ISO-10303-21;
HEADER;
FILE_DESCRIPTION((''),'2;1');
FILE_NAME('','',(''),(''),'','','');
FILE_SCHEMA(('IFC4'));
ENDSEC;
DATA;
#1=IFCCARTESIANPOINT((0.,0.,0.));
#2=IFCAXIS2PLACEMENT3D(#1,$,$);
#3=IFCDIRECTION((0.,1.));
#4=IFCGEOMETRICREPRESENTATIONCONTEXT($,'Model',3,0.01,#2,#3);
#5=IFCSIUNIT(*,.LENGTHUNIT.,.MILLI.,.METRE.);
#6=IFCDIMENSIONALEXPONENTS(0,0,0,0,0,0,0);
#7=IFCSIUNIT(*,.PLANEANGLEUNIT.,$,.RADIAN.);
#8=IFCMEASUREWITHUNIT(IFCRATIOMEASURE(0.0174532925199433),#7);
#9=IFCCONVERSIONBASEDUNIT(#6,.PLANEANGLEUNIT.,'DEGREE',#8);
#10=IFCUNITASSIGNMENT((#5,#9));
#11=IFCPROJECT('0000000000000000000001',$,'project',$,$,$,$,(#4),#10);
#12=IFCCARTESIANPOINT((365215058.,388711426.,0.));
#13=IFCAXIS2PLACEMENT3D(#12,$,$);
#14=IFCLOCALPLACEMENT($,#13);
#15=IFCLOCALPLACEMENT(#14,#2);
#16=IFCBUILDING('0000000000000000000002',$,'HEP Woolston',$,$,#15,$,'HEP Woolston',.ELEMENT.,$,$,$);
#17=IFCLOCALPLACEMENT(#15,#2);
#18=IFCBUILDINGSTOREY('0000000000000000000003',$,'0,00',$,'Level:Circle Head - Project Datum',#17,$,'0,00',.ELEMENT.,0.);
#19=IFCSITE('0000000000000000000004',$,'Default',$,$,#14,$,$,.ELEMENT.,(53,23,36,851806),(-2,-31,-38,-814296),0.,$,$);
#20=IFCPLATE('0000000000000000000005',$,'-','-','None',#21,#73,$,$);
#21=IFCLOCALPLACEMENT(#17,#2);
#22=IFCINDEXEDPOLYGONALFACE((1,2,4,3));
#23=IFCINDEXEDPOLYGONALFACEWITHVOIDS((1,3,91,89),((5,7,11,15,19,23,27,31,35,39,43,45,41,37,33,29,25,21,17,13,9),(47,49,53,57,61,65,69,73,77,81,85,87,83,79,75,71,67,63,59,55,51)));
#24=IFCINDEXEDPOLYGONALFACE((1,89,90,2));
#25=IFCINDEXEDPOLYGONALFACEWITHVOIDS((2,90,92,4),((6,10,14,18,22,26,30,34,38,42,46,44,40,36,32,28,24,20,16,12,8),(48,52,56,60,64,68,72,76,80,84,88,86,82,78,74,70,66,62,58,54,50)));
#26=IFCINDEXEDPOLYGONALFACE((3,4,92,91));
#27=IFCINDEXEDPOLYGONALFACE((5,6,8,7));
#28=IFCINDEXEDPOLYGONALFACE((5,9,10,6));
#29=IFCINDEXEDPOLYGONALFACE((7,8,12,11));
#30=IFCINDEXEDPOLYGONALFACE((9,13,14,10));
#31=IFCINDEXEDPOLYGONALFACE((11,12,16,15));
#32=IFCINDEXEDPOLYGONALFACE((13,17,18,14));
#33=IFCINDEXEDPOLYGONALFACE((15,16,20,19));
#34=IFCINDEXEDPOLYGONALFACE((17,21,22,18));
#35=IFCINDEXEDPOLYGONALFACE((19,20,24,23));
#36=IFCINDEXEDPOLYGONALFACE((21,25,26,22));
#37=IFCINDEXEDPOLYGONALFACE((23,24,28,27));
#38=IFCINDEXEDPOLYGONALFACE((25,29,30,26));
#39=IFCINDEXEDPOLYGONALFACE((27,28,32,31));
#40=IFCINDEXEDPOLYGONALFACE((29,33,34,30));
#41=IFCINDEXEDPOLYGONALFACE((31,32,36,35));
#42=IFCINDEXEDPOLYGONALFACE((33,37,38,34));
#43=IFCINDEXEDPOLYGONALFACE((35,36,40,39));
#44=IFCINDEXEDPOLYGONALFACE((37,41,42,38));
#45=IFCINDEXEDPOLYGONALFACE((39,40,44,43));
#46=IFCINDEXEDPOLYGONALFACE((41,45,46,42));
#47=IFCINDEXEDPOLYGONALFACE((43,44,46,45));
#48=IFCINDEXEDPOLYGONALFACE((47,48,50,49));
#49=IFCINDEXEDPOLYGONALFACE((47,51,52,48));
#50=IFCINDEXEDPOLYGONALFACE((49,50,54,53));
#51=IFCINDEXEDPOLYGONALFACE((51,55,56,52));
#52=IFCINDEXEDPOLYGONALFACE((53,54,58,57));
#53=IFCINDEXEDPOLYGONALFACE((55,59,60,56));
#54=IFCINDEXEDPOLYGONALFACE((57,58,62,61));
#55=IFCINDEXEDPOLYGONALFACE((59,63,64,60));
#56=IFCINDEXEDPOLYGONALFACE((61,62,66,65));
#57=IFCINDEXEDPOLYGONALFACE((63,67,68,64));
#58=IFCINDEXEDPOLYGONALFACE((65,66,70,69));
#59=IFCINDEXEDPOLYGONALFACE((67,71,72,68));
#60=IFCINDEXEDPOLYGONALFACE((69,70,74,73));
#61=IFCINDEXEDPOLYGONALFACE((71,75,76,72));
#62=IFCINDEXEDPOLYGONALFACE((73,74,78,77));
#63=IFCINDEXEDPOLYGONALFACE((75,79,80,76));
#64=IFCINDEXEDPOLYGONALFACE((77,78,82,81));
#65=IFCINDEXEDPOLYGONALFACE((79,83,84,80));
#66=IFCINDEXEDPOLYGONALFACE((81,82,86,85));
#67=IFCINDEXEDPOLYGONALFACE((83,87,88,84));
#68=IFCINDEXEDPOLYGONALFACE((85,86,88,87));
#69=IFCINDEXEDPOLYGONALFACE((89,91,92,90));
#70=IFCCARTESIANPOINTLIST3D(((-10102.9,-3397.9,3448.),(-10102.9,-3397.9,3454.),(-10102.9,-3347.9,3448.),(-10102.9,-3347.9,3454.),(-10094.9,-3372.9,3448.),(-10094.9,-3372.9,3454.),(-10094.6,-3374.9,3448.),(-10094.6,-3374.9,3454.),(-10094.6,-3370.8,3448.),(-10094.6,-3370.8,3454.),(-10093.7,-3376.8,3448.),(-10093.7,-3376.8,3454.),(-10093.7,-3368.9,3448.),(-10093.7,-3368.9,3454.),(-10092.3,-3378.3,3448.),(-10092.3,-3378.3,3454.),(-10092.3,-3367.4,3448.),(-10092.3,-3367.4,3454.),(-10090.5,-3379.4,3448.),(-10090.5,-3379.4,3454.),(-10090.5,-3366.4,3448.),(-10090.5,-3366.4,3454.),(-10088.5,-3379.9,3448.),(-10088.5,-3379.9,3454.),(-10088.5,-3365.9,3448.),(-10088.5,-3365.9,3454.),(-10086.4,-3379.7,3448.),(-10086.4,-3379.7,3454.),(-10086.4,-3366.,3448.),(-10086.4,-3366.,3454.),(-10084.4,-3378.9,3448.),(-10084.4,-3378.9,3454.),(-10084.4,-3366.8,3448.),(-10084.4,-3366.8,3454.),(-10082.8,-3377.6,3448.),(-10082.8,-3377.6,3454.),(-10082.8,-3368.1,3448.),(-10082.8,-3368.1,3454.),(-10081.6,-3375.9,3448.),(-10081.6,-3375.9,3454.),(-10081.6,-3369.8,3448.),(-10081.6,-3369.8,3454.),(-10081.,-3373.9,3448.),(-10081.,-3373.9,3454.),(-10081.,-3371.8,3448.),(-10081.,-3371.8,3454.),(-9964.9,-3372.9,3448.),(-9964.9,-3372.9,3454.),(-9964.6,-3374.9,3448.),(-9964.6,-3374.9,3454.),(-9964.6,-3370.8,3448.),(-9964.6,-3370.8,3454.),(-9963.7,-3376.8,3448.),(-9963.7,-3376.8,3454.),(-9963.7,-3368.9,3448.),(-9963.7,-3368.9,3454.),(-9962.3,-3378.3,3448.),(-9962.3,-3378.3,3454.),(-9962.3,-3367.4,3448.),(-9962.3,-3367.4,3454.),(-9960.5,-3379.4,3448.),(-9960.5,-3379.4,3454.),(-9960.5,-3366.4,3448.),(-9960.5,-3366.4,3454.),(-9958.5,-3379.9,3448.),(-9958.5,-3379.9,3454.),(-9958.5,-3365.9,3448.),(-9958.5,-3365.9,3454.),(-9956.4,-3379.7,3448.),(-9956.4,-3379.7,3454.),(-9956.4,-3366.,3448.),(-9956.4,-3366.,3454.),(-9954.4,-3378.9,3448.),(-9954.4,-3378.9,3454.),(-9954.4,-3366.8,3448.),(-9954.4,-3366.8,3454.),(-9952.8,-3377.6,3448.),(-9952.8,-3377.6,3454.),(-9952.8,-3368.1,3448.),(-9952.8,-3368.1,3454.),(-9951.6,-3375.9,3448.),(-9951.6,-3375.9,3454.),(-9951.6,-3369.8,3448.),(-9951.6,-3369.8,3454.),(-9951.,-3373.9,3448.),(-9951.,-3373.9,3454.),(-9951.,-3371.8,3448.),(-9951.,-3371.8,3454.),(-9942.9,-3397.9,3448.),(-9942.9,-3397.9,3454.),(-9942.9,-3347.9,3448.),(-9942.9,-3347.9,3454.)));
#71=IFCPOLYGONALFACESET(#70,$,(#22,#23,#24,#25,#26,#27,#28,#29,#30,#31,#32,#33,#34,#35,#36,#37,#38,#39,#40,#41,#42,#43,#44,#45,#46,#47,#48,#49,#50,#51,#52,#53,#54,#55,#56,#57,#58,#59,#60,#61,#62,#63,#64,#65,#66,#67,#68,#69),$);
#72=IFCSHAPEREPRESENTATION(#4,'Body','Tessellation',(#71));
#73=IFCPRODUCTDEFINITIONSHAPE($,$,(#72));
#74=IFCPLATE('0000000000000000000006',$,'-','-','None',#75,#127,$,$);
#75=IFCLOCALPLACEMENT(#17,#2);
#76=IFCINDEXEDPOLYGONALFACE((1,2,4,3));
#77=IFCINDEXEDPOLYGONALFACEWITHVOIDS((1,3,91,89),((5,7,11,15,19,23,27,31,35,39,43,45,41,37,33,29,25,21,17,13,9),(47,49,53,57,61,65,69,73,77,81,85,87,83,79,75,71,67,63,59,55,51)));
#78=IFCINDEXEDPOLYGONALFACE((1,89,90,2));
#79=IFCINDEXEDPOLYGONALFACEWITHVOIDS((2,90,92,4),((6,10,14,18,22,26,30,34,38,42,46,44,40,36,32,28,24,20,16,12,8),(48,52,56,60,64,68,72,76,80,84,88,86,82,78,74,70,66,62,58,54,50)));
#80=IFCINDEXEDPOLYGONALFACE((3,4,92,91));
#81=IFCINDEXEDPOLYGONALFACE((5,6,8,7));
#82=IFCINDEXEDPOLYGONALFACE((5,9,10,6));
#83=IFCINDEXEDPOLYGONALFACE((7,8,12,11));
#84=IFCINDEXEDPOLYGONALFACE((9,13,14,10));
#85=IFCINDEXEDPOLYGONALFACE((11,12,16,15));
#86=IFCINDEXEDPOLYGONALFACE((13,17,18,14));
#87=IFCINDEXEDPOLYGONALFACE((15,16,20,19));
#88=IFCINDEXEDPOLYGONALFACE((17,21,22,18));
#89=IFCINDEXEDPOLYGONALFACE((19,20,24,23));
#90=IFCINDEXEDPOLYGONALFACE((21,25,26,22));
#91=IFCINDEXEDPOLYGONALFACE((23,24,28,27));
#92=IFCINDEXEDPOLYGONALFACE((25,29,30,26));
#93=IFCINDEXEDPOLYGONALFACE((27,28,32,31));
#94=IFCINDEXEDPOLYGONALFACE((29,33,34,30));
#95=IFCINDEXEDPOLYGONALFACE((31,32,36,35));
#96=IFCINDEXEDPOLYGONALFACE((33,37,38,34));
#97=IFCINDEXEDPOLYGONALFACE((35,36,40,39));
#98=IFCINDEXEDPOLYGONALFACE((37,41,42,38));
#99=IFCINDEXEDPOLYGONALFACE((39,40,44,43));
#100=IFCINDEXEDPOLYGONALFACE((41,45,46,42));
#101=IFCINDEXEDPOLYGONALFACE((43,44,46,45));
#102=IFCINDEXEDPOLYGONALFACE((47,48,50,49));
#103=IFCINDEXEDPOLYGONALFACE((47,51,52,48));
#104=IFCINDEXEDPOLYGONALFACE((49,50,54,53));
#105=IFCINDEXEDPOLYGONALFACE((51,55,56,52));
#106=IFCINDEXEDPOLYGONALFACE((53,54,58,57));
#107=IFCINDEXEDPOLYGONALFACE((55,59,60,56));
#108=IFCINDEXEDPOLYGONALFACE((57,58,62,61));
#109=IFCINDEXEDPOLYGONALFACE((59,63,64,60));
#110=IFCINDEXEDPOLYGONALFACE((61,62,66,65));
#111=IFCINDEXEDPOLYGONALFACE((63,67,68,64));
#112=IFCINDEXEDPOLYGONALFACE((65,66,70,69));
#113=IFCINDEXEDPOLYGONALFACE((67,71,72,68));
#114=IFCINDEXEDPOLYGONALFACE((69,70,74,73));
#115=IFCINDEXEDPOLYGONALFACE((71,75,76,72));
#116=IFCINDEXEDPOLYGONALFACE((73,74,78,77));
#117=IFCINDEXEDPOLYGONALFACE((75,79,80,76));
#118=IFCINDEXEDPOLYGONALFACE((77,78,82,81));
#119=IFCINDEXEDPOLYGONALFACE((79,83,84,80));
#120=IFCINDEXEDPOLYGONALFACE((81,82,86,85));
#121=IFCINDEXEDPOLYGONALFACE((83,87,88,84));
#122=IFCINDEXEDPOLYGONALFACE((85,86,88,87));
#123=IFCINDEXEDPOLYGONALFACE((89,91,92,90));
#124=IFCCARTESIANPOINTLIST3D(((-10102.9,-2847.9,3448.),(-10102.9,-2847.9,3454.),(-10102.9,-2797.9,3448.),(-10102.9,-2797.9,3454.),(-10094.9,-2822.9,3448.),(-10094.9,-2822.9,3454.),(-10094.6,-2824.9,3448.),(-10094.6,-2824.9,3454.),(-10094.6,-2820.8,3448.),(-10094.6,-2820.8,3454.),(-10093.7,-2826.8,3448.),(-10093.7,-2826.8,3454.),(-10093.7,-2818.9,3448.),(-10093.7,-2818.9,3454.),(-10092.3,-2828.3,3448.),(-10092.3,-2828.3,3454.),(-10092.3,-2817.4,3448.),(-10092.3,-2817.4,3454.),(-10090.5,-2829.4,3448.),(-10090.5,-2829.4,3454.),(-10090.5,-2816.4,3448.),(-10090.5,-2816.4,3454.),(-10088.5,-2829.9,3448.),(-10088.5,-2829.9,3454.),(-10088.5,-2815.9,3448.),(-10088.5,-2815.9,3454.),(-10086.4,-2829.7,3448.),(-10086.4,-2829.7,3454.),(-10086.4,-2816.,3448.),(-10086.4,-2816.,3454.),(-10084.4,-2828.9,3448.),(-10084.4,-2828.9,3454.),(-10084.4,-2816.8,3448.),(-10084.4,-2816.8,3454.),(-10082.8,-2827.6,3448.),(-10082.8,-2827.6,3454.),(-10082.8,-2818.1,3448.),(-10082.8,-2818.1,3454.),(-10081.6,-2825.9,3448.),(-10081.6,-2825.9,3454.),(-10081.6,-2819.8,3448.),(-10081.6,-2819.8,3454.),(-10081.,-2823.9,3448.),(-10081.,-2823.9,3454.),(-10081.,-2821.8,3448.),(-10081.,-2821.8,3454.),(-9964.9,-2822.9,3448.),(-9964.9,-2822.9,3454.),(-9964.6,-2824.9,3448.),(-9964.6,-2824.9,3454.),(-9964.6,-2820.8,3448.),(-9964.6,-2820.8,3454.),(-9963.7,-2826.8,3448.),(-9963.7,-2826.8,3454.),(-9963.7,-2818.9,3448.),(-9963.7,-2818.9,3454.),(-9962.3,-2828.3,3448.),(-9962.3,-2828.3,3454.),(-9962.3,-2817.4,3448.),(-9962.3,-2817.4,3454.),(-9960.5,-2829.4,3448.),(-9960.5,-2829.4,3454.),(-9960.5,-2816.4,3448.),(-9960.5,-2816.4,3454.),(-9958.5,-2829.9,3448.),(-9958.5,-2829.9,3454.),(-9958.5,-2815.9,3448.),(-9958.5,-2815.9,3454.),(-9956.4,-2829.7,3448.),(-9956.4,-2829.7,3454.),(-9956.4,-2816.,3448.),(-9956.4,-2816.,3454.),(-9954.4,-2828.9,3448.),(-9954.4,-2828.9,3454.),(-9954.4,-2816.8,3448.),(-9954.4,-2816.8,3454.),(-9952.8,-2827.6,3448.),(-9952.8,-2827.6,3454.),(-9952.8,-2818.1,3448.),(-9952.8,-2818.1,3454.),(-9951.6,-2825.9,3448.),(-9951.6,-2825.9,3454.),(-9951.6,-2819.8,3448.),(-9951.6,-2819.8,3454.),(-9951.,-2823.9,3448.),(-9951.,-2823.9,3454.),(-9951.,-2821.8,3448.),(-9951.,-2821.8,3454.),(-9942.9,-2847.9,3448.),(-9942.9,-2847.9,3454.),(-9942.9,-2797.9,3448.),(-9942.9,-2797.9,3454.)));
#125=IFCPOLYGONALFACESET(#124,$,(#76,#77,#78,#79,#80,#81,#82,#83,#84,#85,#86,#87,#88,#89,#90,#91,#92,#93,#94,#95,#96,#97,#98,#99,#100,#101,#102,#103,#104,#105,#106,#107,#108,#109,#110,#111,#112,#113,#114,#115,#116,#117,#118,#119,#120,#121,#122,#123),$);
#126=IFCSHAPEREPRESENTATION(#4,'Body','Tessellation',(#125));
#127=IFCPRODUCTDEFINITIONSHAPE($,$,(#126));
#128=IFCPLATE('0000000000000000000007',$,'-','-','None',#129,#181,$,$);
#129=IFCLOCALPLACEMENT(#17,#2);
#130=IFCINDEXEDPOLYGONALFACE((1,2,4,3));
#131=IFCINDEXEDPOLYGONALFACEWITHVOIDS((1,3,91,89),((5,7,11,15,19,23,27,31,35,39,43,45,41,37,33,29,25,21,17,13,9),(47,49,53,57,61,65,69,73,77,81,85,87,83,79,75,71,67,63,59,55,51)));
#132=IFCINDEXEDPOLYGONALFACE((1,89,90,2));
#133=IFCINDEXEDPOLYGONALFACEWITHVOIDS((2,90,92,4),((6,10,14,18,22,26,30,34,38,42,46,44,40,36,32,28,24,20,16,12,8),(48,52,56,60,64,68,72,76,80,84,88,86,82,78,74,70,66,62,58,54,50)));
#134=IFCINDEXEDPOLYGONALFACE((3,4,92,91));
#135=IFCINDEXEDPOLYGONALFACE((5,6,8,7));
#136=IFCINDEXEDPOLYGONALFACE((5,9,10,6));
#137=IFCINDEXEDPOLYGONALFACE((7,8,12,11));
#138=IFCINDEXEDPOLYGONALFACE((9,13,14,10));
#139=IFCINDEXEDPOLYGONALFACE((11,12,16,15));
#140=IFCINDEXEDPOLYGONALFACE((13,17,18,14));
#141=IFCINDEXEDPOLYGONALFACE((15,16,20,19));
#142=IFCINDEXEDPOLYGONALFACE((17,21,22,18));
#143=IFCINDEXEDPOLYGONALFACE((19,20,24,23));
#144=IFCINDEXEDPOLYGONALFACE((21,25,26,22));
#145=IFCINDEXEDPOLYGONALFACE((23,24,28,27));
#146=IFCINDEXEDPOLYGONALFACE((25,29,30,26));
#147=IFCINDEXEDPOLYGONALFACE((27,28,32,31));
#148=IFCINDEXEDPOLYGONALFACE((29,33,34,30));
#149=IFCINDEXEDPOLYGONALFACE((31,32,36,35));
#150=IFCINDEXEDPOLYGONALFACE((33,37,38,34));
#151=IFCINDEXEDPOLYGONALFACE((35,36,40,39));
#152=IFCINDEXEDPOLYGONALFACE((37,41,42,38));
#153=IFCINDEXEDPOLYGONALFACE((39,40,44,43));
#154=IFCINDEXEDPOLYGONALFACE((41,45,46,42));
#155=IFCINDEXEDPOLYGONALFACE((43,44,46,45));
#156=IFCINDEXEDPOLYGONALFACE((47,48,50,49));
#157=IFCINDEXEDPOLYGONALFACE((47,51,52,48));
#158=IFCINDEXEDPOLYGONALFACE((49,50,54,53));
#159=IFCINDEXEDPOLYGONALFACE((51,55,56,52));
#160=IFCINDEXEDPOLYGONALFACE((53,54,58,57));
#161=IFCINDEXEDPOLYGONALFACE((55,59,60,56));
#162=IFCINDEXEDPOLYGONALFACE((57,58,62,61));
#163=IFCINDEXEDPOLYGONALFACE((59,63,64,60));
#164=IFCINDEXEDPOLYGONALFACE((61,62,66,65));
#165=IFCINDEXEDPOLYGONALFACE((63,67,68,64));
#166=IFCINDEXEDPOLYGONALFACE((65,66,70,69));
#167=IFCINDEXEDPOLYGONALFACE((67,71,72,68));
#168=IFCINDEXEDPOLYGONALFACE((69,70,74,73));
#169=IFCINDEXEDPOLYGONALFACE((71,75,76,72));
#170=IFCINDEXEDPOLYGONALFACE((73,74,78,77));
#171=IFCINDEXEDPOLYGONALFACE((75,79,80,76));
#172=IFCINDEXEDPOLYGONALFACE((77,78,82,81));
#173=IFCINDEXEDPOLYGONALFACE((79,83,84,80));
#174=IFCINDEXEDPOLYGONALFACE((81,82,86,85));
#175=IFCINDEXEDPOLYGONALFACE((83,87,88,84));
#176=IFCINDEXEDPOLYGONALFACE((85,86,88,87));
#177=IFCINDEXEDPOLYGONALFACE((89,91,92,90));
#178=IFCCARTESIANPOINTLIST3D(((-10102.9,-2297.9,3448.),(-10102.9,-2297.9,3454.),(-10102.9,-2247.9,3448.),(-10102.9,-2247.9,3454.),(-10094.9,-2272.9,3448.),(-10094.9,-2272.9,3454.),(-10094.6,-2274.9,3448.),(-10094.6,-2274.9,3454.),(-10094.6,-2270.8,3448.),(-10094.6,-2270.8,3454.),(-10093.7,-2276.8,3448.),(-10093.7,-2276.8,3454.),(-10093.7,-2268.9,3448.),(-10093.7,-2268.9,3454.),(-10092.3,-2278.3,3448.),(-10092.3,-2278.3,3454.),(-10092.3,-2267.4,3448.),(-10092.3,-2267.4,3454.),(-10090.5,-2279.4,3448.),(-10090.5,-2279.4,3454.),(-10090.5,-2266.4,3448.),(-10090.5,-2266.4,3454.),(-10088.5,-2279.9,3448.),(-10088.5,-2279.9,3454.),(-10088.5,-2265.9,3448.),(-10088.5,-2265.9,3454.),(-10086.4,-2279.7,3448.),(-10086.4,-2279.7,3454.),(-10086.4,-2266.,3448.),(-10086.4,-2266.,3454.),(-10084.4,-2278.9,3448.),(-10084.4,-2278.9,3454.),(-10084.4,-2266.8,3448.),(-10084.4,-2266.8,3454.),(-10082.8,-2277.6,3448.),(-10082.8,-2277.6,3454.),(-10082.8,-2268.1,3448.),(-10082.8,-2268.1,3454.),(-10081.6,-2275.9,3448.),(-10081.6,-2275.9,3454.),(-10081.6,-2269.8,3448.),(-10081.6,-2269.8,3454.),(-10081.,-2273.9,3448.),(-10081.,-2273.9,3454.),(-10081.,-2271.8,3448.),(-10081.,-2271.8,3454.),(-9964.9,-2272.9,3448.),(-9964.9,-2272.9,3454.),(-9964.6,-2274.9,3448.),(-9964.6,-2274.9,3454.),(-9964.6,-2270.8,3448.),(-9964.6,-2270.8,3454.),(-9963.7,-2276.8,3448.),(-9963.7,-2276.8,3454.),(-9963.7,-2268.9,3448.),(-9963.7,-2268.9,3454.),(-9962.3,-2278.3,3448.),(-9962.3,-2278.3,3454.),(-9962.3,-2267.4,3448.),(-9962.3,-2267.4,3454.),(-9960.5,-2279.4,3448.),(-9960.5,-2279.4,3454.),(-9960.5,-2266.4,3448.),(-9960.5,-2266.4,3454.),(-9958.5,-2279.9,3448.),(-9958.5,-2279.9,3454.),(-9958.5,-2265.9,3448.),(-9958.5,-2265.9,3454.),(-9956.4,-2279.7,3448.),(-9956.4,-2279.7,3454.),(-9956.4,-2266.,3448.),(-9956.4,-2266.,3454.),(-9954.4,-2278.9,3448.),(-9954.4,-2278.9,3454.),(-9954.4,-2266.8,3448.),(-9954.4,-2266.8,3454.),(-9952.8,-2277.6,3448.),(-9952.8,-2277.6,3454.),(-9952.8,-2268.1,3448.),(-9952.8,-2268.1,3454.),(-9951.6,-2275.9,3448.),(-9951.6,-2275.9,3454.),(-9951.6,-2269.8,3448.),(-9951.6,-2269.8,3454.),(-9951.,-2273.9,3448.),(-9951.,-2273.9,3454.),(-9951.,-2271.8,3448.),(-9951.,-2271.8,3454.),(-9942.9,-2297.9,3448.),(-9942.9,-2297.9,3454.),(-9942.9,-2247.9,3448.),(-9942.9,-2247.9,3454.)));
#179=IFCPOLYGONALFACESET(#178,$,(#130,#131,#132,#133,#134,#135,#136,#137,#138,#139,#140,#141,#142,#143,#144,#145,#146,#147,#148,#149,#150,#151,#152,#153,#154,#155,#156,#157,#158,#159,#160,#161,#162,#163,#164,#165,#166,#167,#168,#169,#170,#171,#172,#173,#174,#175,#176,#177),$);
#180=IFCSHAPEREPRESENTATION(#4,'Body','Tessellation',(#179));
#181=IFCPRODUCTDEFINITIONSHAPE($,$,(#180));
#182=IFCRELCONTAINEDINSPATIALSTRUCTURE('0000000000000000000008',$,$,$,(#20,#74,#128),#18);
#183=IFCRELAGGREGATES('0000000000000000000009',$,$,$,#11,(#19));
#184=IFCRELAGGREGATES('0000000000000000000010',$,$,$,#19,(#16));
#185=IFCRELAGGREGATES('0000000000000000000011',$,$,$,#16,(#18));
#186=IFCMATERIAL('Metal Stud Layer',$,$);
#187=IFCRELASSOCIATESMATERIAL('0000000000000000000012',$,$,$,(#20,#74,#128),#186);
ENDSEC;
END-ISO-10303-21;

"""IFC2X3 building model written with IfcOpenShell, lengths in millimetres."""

from ifc_helpers import new_model, entity, si_unit, converted_unit, direction, frame, frame_2d, origin, origin_with_axes, place, context, project, spatial, polyline, circle, outline, extrude, material, element, save


model = new_model("IFC2X3")

# Units and contexts
model_context = context("Model", 3, precision=0.01, world=origin(), true_north=direction((0.0, 1.0)))
ifc_project = project(units=[si_unit("LENGTHUNIT", "METRE", prefix="MILLI"), converted_unit("PLANEANGLEUNIT", "DEGREE", entity("IfcRatioMeasure", 0.0174532925199433), si_unit("PLANEANGLEUNIT", "RADIAN"), dimensions=[0, 0, 0, 0, 0, 0, 0])], contexts=[model_context])

# Site, building, storey
site_placement = place(None, frame((365215058.0, 388711426.0, 0.0)))
site = spatial("IfcSite", under=ifc_project, at=site_placement, Name="Default", CompositionType="ELEMENT", RefLatitude=(53, 23, 36, 851806), RefLongitude=(-2, -31, -38, -814296), RefElevation=0.0)
building_placement = place(site_placement, origin())
building = spatial("IfcBuilding", under=site, at=building_placement, Name="HEP Woolston", LongName="HEP Woolston", CompositionType="ELEMENT")
storey_placement = place(building_placement, origin())
storey = spatial("IfcBuildingStorey", under=building, at=storey_placement, Name="0,00", ObjectType="Level:Circle Head - Project Datum", LongName="0,00", CompositionType="ELEMENT", Elevation=0.0)

# Plates, openings
ifc_material = material(Name="Metal Stud Layer")
plate_1_placement = place(storey_placement, frame((-9942.9, -3397.9, 3454.0), z_axis=(0.0, 0.0, -1.0), x_axis=(-1.0, 0.0, 0.0)))
plate_1 = element("IfcPlate", 1, at=plate_1_placement, inside=storey, material=ifc_material, Name="-", Description="-", ObjectType="None", context=model_context, shape_type="SweptSolid", body=[
    extrude(outline(polyline([(160.0, 0.0), (160.0, 50.0), (0.0, 50.0), (0.0, 0.0), (160.0, 0.0)])), origin_with_axes(), (0.0, 0.0, 1.0), 6.0),
])
opening_1_placement = place(plate_1_placement, frame((80.0, 25.0, 6.5), z_axis=(0.0, 0.0, -1.0), x_axis=(1.0, 0.0, 0.0)))
element("IfcOpeningElement", 2, at=opening_1_placement, cuts=plate_1, ObjectType="Opening", context=model_context, shape_type="SweptSolid", body=[
    extrude(circle(Radius=7.0, at=frame_2d((65.0, 0.0), x_axis=(1.0, 0.0))), origin(), (0.0, 0.0, 1.0), 7.0),
])
opening_2_placement = place(plate_1_placement, frame((80.0, 25.0, 6.5), z_axis=(0.0, 0.0, -1.0), x_axis=(1.0, 0.0, 0.0)))
element("IfcOpeningElement", 3, at=opening_2_placement, cuts=plate_1, ObjectType="Opening", context=model_context, shape_type="SweptSolid", body=[
    extrude(circle(Radius=7.0, at=frame_2d((-65.0, 0.0), x_axis=(1.0, 0.0))), origin(), (0.0, 0.0, 1.0), 7.0),
])
plate_2_placement = place(storey_placement, frame((-9942.9, -2847.9, 3454.0), z_axis=(0.0, 0.0, -1.0), x_axis=(-1.0, 0.0, 0.0)))
plate_2 = element("IfcPlate", 4, at=plate_2_placement, inside=storey, material=ifc_material, Name="-", Description="-", ObjectType="None", context=model_context, shape_type="SweptSolid", body=[
    extrude(outline(polyline([(160.0, 0.0), (160.0, 50.0), (0.0, 50.0), (0.0, 0.0), (160.0, 0.0)])), origin_with_axes(), (0.0, 0.0, 1.0), 6.0),
])
opening_3_placement = place(plate_2_placement, frame((80.0, 25.0, 6.5), z_axis=(0.0, 0.0, -1.0), x_axis=(1.0, 0.0, 0.0)))
element("IfcOpeningElement", 5, at=opening_3_placement, cuts=plate_2, ObjectType="Opening", context=model_context, shape_type="SweptSolid", body=[
    extrude(circle(Radius=7.0, at=frame_2d((65.0, 0.0), x_axis=(1.0, 0.0))), origin(), (0.0, 0.0, 1.0), 7.0),
])
opening_4_placement = place(plate_2_placement, frame((80.0, 25.0, 6.5), z_axis=(0.0, 0.0, -1.0), x_axis=(1.0, 0.0, 0.0)))
element("IfcOpeningElement", 6, at=opening_4_placement, cuts=plate_2, ObjectType="Opening", context=model_context, shape_type="SweptSolid", body=[
    extrude(circle(Radius=7.0, at=frame_2d((-65.0, 0.0), x_axis=(1.0, 0.0))), origin(), (0.0, 0.0, 1.0), 7.0),
])
plate_3_placement = place(storey_placement, frame((-9942.9, -2297.9, 3454.0), z_axis=(0.0, 0.0, -1.0), x_axis=(-1.0, 0.0, 0.0)))
plate_3 = element("IfcPlate", 7, at=plate_3_placement, inside=storey, material=ifc_material, Name="-", Description="-", ObjectType="None", context=model_context, shape_type="SweptSolid", body=[
    extrude(outline(polyline([(160.0, 0.0), (160.0, 50.0), (0.0, 50.0), (0.0, 0.0), (160.0, 0.0)])), origin_with_axes(), (0.0, 0.0, 1.0), 6.0),
])
opening_5_placement = place(plate_3_placement, frame((80.0, 25.0, 6.5), z_axis=(0.0, 0.0, -1.0), x_axis=(1.0, 0.0, 0.0)))
element("IfcOpeningElement", 8, at=opening_5_placement, cuts=plate_3, ObjectType="Opening", context=model_context, shape_type="SweptSolid", body=[
    extrude(circle(Radius=7.0, at=frame_2d((65.0, 0.0), x_axis=(1.0, 0.0))), origin(), (0.0, 0.0, 1.0), 7.0),
])
opening_6_placement = place(plate_3_placement, frame((80.0, 25.0, 6.5), z_axis=(0.0, 0.0, -1.0), x_axis=(1.0, 0.0, 0.0)))
element("IfcOpeningElement", 9, at=opening_6_placement, cuts=plate_3, ObjectType="Opening", context=model_context, shape_type="SweptSolid", body=[
    extrude(circle(Radius=7.0, at=frame_2d((-65.0, 0.0), x_axis=(1.0, 0.0))), origin(), (0.0, 0.0, 1.0), 7.0),
])

save(model, "model.ifc")
